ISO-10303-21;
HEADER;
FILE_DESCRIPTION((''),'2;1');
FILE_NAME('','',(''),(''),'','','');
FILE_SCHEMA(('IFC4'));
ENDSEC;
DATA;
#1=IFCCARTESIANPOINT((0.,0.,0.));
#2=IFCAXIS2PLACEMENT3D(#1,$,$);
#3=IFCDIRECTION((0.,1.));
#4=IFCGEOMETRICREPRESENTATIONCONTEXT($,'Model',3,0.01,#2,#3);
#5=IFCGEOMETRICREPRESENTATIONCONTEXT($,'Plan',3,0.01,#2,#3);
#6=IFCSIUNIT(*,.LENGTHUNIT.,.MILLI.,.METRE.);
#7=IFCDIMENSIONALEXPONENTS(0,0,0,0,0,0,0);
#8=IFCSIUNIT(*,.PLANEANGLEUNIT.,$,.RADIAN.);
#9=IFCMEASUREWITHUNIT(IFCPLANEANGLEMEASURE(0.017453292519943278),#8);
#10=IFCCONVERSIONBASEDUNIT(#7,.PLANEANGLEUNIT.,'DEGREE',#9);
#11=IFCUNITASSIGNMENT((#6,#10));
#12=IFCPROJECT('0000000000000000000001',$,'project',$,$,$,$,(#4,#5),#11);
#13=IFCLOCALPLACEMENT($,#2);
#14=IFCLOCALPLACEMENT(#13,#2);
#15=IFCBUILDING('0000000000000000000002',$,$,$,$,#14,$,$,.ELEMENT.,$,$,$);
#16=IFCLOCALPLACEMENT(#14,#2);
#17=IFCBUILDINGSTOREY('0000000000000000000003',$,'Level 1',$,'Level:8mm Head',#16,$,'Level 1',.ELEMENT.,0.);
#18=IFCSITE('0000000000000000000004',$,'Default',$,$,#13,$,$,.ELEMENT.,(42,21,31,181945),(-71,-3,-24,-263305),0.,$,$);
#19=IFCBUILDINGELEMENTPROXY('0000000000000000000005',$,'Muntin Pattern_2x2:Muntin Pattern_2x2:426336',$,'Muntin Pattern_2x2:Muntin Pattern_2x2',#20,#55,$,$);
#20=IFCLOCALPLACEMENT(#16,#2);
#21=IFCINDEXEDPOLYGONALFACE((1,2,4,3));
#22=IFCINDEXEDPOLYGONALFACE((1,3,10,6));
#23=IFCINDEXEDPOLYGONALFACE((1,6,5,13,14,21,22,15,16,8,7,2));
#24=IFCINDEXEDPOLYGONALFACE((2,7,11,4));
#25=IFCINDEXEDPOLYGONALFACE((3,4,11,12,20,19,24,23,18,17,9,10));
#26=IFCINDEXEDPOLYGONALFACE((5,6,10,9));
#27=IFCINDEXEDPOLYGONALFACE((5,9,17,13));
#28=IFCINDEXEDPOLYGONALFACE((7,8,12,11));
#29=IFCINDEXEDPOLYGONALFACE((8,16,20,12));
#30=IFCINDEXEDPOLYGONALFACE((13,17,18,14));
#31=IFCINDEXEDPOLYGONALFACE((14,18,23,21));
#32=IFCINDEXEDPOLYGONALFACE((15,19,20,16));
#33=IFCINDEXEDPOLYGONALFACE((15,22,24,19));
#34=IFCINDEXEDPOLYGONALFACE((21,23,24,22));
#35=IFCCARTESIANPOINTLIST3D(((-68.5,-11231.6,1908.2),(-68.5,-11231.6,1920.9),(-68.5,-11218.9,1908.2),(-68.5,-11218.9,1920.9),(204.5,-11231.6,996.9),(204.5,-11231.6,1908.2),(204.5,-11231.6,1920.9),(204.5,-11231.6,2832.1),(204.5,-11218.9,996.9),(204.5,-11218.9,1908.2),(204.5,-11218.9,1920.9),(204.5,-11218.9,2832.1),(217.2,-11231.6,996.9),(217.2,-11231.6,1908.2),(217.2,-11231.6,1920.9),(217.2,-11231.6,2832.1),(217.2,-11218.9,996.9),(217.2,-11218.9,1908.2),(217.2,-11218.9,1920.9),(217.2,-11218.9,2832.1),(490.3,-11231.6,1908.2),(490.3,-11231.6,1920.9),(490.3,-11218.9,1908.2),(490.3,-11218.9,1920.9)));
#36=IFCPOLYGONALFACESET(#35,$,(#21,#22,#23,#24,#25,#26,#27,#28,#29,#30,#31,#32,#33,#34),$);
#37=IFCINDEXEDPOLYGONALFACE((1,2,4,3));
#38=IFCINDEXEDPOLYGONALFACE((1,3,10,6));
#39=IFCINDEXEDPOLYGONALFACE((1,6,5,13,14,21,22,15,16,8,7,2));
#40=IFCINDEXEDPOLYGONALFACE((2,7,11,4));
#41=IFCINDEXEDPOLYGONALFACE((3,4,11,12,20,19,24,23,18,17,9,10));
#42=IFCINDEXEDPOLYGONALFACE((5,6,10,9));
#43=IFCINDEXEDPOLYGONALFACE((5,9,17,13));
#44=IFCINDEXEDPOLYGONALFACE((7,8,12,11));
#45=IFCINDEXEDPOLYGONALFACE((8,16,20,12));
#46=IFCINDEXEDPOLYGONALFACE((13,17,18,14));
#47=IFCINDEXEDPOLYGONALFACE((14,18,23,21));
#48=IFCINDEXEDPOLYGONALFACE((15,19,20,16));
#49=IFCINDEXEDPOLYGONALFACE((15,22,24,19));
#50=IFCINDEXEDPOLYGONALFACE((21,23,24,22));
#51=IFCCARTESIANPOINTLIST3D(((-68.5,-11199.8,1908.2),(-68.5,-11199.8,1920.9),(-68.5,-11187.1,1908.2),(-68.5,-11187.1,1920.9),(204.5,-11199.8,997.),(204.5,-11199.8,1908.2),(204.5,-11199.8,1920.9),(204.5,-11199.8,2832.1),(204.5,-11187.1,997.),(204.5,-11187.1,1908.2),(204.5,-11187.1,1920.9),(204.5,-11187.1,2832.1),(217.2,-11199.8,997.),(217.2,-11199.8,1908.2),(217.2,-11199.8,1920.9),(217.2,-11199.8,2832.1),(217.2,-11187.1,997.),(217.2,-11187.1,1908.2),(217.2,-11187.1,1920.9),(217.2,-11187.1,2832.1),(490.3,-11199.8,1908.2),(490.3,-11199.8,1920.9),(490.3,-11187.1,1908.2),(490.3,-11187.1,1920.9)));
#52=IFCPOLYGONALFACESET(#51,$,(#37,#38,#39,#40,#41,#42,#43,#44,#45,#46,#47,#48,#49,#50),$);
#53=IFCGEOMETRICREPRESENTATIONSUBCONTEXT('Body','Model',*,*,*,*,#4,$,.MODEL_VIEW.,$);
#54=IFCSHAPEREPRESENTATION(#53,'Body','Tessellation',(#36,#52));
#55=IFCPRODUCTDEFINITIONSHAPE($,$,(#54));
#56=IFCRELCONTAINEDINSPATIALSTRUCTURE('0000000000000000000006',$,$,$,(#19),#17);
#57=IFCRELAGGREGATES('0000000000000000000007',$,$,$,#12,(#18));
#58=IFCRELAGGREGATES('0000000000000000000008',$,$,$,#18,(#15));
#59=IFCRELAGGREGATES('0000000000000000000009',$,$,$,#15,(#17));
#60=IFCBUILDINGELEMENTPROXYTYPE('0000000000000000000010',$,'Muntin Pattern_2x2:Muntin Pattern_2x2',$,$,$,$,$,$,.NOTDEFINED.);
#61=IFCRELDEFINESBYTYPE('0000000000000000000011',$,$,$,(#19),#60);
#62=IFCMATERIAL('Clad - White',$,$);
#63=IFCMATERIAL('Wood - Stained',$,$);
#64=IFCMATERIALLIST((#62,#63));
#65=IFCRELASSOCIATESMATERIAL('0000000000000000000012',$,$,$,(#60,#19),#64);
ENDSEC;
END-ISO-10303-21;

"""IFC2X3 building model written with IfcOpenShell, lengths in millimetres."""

from ifc_helpers import new_model, entity, si_unit, converted_unit, direction, frame, origin, place, context, subcontext, project, spatial, polyline, outline, extrude, source, transform, mapped, material, material_list, type_object, type_shapes, element, save


model = new_model("IFC2X3")

# Units and contexts
model_context = context("Model", 3, precision=0.01, world=origin(), true_north=direction((0.0, 1.0)))
plan_context = context("Plan", 3, precision=0.01, world=origin(), true_north=direction((0.0, 1.0)))
body_context = subcontext(model_context, "Body", "Model", "MODEL_VIEW")
ifc_project = project(units=[si_unit("LENGTHUNIT", "METRE", prefix="MILLI"), converted_unit("PLANEANGLEUNIT", "DEGREE", entity("IfcPlaneAngleMeasure", 0.017453292519943278), si_unit("PLANEANGLEUNIT", "RADIAN"), dimensions=[0, 0, 0, 0, 0, 0, 0])], contexts=[model_context, plan_context])

# Site, building, storey
site_placement = place(None, origin())
site = spatial("IfcSite", under=ifc_project, at=site_placement, Name="Default", CompositionType="ELEMENT", RefLatitude=(42, 21, 31, 181945), RefLongitude=(-71, -3, -24, -263305), RefElevation=0.0)
building_placement = place(site_placement, origin())
building = spatial("IfcBuilding", under=site, at=building_placement, CompositionType="ELEMENT")
storey_placement = place(building_placement, origin())
storey = spatial("IfcBuildingStorey", under=building, at=storey_placement, Name="Level 1", ObjectType="Level:8mm Head", LongName="Level 1", CompositionType="ELEMENT", Elevation=0.0)

# Building element proxy
ifc_material_1 = material(Name="Clad - White")
ifc_material_2 = material(Name="Wood - Stained")
ifc_material_list = material_list([ifc_material_1, ifc_material_2])
building_element_proxy_type_1 = type_object("IfcBuildingElementProxyType", Name="Muntin Pattern_2x2:Muntin Pattern_2x2", PredefinedType="NOTDEFINED", material=ifc_material_list)
shared_shape_1 = source(origin(), body_context, "Body", "SweptSolid", [
    extrude(outline(polyline([(6.4, -6.4), (917.6, -6.4), (917.6, 6.3), (6.4, 6.3), (6.4, 279.4), (-6.3, 279.4), (-6.3, 6.3), (-917.6, 6.3), (-917.6, -6.4), (-6.3, -6.4), (-6.3, -279.4), (6.4, -279.4), (6.4, -6.4)])), frame((0.0, 9.5, 917.6), z_axis=(0.0, 1.0, 0.0), x_axis=(0.0, 0.0, 1.0)), (0.0, 0.0, 1.0), 12.7),
    extrude(outline(polyline([(6.4, -6.4), (917.6, -6.4), (917.6, 6.3), (6.4, 6.3), (6.4, 279.4), (-6.3, 279.4), (-6.3, 6.3), (-917.6, 6.3), (-917.6, -6.4), (-6.3, -6.4), (-6.3, -279.4), (6.4, -279.4), (6.4, -6.4)])), frame((0.0, -22.2, 917.6), z_axis=(0.0, 1.0, 0.0), x_axis=(0.0, 0.0, 1.0)), (0.0, 0.0, 1.0), 12.7),
])
type_shapes(building_element_proxy_type_1, [shared_shape_1])
proxy_1_placement = place(storey_placement, frame((210.9, -11209.4, 997.0), z_axis=(0.0, 0.0, 1.0), x_axis=(-1.0, 0.0, 0.0)))
element("IfcBuildingElementProxy", 1, at=proxy_1_placement, inside=storey, type_object=building_element_proxy_type_1, material=ifc_material_list, Name="Muntin Pattern_2x2:Muntin Pattern_2x2:426336", ObjectType="Muntin Pattern_2x2:Muntin Pattern_2x2", context=body_context, shape_type="MappedRepresentation", body=[
    mapped(shared_shape_1, transform((0.0, 0.0, 0.0), scale=1.0)),
])

save(model, "model.ifc")
